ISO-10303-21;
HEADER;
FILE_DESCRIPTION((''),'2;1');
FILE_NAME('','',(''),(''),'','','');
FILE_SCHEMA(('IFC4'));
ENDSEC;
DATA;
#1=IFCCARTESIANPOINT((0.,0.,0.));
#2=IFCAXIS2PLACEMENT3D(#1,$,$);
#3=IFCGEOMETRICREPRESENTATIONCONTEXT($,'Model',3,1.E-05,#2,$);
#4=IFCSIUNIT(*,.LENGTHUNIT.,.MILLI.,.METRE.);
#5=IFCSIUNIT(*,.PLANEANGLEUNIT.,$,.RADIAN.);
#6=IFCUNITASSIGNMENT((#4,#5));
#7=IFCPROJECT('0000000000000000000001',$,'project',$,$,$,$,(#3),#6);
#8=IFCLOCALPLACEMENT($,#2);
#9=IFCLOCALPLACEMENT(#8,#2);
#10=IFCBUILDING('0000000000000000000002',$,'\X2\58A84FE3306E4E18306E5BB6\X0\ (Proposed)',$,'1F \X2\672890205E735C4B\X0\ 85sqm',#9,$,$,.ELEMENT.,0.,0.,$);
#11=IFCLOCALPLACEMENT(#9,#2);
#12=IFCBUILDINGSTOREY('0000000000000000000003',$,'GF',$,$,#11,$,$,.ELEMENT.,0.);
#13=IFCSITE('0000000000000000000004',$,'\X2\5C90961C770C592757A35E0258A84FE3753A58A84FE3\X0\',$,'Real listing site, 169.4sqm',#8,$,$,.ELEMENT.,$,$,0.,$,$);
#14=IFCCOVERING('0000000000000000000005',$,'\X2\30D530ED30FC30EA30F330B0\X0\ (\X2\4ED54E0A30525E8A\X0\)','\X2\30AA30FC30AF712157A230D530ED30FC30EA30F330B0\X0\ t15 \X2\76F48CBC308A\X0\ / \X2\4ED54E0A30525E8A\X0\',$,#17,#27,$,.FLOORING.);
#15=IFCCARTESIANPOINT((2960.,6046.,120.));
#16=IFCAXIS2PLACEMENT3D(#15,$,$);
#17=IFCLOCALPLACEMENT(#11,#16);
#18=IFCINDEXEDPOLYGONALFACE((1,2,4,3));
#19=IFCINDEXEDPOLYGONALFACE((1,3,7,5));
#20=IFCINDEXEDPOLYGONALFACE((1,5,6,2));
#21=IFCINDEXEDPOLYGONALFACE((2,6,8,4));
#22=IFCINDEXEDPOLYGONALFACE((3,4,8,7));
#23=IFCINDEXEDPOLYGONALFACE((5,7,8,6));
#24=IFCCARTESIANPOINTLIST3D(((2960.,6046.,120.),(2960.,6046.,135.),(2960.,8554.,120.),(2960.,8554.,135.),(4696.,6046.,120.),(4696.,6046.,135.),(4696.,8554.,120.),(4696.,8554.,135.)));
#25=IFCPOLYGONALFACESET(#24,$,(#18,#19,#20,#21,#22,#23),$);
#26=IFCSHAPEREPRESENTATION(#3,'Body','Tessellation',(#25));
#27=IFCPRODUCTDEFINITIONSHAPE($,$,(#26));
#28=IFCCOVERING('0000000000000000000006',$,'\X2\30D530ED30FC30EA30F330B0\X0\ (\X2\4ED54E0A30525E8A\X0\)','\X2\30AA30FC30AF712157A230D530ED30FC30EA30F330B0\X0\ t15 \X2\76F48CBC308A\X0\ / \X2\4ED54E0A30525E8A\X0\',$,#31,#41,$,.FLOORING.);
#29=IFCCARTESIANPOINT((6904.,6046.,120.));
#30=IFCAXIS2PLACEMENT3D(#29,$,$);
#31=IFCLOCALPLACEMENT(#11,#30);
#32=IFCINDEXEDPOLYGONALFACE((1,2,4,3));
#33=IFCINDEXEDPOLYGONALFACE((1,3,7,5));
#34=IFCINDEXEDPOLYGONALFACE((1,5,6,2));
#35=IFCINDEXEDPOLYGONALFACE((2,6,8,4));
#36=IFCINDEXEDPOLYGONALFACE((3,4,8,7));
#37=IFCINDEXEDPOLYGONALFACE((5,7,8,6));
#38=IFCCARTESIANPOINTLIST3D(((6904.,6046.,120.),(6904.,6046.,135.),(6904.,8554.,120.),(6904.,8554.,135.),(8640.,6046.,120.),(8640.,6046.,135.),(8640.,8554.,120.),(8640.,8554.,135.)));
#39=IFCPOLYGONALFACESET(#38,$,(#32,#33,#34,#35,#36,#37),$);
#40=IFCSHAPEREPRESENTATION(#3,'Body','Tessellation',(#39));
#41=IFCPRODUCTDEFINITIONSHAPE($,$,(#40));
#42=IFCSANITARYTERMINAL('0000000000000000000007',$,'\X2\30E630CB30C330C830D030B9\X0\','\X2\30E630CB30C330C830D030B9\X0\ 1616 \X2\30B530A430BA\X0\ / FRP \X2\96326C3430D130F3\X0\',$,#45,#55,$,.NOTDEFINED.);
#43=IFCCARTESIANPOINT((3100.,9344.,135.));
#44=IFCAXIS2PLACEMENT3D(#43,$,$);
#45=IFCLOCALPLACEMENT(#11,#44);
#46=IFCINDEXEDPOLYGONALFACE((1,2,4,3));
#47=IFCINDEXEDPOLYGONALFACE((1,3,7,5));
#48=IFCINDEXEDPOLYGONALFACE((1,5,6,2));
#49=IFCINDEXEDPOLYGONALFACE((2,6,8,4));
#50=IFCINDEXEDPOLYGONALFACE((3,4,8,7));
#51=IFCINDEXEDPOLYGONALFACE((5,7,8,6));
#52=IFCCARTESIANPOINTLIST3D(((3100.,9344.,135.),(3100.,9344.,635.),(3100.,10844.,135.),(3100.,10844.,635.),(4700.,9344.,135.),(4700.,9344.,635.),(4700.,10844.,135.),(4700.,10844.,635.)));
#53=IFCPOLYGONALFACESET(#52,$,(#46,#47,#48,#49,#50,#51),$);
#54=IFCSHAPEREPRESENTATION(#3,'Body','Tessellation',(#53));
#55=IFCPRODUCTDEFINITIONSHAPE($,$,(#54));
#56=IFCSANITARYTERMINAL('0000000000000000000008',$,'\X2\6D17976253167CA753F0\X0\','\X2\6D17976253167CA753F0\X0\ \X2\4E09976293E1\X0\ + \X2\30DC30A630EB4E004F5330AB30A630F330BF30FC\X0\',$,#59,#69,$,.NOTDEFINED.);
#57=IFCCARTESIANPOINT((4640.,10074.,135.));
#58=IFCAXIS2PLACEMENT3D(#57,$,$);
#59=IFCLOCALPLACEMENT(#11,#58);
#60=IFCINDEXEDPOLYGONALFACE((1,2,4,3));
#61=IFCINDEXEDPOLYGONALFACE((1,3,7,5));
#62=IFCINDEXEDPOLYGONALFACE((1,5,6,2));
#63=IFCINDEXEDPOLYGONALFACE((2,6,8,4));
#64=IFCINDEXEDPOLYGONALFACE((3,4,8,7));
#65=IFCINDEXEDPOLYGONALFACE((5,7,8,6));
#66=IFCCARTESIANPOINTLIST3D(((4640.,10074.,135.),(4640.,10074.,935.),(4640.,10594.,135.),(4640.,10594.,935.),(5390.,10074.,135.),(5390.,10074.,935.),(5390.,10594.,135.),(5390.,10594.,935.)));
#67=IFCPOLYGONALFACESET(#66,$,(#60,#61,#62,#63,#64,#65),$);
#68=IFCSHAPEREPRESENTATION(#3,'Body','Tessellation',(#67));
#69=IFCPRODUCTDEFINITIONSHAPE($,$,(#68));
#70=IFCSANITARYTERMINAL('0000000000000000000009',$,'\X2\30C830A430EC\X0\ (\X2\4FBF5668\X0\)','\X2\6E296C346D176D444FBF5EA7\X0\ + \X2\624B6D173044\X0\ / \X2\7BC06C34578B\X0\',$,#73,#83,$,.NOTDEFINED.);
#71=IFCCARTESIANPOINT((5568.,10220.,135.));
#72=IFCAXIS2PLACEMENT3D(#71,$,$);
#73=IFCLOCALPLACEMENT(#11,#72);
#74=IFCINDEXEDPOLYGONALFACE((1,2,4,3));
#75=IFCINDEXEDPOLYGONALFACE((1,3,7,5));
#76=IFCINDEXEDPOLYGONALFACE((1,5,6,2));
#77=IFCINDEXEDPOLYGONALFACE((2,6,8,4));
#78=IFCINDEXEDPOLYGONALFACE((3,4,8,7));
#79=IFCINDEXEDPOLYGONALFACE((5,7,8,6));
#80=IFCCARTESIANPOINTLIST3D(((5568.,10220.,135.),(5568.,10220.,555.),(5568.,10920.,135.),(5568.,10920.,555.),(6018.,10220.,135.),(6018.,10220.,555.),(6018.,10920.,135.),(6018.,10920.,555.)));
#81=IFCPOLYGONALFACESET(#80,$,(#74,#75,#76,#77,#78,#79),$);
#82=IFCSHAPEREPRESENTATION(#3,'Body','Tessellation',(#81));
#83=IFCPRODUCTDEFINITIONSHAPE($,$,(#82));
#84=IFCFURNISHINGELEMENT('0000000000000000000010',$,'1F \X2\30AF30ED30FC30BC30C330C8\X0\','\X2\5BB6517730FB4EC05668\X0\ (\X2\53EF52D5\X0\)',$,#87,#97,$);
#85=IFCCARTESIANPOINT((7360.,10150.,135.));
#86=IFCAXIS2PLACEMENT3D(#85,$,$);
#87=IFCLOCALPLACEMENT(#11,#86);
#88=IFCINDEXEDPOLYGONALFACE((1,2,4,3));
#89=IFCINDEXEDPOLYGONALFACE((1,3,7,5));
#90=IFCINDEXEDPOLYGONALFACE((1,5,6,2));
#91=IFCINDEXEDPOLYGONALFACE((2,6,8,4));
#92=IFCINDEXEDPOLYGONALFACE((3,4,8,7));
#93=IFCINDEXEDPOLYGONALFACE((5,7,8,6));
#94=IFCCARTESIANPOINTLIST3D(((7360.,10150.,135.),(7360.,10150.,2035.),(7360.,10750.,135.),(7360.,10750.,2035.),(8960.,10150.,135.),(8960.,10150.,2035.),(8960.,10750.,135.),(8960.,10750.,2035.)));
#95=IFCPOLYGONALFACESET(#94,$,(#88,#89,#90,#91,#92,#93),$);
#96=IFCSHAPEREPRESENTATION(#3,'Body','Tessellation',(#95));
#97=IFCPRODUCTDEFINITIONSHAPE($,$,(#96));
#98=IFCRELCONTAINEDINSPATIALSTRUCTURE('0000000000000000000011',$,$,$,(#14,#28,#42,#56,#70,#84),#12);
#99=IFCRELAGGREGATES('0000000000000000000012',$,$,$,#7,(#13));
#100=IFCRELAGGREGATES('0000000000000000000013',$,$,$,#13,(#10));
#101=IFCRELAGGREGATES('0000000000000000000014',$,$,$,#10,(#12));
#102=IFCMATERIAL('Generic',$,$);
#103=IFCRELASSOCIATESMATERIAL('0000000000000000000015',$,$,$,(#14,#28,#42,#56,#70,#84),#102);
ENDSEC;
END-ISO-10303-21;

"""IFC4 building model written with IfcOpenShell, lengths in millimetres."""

from ifc_helpers import new_model, si_unit, frame, frame_2d, origin, place, context, project, spatial, rectangle, extrude, material, element, save


model = new_model("IFC4")

# Units and contexts
model_context = context("Model", 3, precision=1e-05, world=origin())
ifc_project = project(units=[si_unit("LENGTHUNIT", "METRE", prefix="MILLI"), si_unit("PLANEANGLEUNIT", "RADIAN")], contexts=[model_context])

# Site, building, storey
site_placement = place(None, origin())
site = spatial("IfcSite", under=ifc_project, at=site_placement, Name="岐阜県大垣市墨俣町墨俣", ObjectType="Real listing site, 169.4sqm", CompositionType="ELEMENT", RefElevation=0.0)
building_placement = place(site_placement, origin())
building = spatial("IfcBuilding", under=site, at=building_placement, Name="墨俣の丘の家 (Proposed)", ObjectType="1F 木造平屋 85sqm", CompositionType="ELEMENT", ElevationOfRefHeight=0.0, ElevationOfTerrain=0.0)
storey_placement = place(building_placement, origin())
storey = spatial("IfcBuildingStorey", under=building, at=storey_placement, Name="GF", CompositionType="ELEMENT", Elevation=0.0)

# Coverings
ifc_material_1 = material(Name="Generic")
covering_1_placement = place(storey_placement, frame((2960.0, 6046.0, 120.0)))
element("IfcCovering", 1, at=covering_1_placement, inside=storey, material=ifc_material_1, Name="フローリング (仕上げ床)", Description="オーク無垢フローリング t15 直貼り / 仕上げ床", PredefinedType="FLOORING", context=model_context, shape_type="SweptSolid", body=[
    extrude(rectangle(XDim=1736.0, YDim=2508.0, at=frame_2d((868.0, 1254.0))), frame((2960.0, 6046.0, 120.0)), (0.0, 0.0, 1.0), 15.0),
])
covering_2_placement = place(storey_placement, frame((6904.0, 6046.0, 120.0)))
element("IfcCovering", 2, at=covering_2_placement, inside=storey, material=ifc_material_1, Name="フローリング (仕上げ床)", Description="オーク無垢フローリング t15 直貼り / 仕上げ床", PredefinedType="FLOORING", context=model_context, shape_type="SweptSolid", body=[
    extrude(rectangle(XDim=1736.0, YDim=2508.0, at=frame_2d((868.0, 1254.0))), frame((6904.0, 6046.0, 120.0)), (0.0, 0.0, 1.0), 15.0),
])

# Sanitary terminals
sanitary_terminal_1_placement = place(storey_placement, frame((3100.0, 9344.0, 135.0)))
element("IfcSanitaryTerminal", 3, at=sanitary_terminal_1_placement, inside=storey, material=ifc_material_1, Name="ユニットバス", Description="ユニットバス 1616 サイズ / FRP 防水パン", PredefinedType="NOTDEFINED", context=model_context, shape_type="SweptSolid", body=[
    extrude(rectangle(XDim=1600.0, YDim=1500.0, at=frame_2d((800.0, 750.0))), frame((3100.0, 9344.0, 135.0)), (0.0, 0.0, 1.0), 500.0),
])
sanitary_terminal_2_placement = place(storey_placement, frame((4640.0, 10074.0, 135.0)))
element("IfcSanitaryTerminal", 4, at=sanitary_terminal_2_placement, inside=storey, material=ifc_material_1, Name="洗面化粧台", Description="洗面化粧台 三面鏡 + ボウル一体カウンター", PredefinedType="NOTDEFINED", context=model_context, shape_type="SweptSolid", body=[
    extrude(rectangle(XDim=750.0, YDim=520.0, at=frame_2d((375.0, 260.0))), frame((4640.0, 10074.0, 135.0)), (0.0, 0.0, 1.0), 800.0),
])
sanitary_terminal_3_placement = place(storey_placement, frame((5568.0, 10220.0, 135.0)))
element("IfcSanitaryTerminal", 5, at=sanitary_terminal_3_placement, inside=storey, material=ifc_material_1, Name="トイレ (便器)", Description="温水洗浄便座 + 手洗い / 節水型", PredefinedType="NOTDEFINED", context=model_context, shape_type="SweptSolid", body=[
    extrude(rectangle(XDim=450.0, YDim=700.0, at=frame_2d((225.0, 350.0))), frame((5568.0, 10220.0, 135.0)), (0.0, 0.0, 1.0), 420.0),
])

# Furnishing element
furnishing_placement = place(storey_placement, frame((7360.0, 10150.0, 135.0)))
element("IfcFurnishingElement", 6, at=furnishing_placement, inside=storey, material=ifc_material_1, Name="1F クローゼット", Description="家具・什器 (可動)", context=model_context, shape_type="SweptSolid", body=[
    extrude(rectangle(XDim=1600.0, YDim=600.0, at=frame_2d((800.0, 300.0))), frame((7360.0, 10150.0, 135.0)), (0.0, 0.0, 1.0), 1900.0),
])

save(model, "model.ifc")
